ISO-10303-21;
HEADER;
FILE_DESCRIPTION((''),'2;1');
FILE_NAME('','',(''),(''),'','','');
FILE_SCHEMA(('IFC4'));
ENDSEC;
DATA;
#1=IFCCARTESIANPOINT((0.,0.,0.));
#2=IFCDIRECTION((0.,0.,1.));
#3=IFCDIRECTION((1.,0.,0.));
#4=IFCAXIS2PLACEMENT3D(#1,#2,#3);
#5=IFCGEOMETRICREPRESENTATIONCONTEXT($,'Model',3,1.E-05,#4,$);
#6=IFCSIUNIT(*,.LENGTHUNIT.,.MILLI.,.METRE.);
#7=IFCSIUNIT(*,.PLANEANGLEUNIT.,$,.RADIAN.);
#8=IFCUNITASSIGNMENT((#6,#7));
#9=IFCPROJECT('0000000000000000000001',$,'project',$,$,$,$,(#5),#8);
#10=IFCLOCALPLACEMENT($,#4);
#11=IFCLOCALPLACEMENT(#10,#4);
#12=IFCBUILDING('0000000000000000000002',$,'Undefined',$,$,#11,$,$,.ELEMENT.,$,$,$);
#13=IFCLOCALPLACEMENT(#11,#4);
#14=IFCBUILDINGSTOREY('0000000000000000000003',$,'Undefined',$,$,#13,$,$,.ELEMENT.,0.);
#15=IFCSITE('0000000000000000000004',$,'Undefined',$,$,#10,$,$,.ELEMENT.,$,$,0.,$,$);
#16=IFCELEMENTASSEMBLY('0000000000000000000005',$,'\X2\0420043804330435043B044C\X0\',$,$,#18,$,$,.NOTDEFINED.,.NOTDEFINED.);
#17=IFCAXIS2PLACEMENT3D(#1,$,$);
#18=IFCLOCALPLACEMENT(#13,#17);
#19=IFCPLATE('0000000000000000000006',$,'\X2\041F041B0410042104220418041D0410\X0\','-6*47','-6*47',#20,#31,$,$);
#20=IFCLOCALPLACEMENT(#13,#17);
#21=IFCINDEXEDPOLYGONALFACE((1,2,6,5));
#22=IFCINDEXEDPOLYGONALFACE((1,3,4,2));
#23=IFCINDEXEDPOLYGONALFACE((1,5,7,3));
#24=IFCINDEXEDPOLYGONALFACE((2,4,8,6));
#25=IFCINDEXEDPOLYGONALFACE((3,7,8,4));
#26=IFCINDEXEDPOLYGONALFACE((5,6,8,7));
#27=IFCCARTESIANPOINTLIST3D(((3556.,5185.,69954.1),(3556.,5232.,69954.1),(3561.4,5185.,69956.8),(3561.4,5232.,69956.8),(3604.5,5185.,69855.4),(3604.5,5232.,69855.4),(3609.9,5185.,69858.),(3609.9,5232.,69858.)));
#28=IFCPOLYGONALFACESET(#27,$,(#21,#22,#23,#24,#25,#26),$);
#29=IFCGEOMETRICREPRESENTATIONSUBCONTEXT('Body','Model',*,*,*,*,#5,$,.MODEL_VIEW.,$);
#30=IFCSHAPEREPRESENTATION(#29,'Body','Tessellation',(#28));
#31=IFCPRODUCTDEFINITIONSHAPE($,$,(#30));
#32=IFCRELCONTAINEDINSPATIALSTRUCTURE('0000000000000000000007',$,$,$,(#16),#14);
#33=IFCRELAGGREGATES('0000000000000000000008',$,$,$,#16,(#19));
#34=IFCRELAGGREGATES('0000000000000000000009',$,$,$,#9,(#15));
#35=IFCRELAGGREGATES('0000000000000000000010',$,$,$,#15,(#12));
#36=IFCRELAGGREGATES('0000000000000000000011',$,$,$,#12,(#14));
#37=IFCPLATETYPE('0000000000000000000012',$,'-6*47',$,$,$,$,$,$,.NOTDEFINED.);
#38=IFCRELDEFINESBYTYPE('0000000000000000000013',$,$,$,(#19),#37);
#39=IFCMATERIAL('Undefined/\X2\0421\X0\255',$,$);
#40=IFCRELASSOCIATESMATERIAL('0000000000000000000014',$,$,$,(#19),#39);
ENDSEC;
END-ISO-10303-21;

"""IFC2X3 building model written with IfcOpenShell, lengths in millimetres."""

from ifc_helpers import new_model, si_unit, frame, origin_with_axes, origin_2d_with_axis, place, context, subcontext, project, spatial, polyline, rectangle, outline, extrude, boolean, material, type_object, element, aggregate, save


model = new_model("IFC2X3")

# Units and contexts
model_context = context("Model", 3, precision=1e-05, world=origin_with_axes())
body_context = subcontext(model_context, "Body", "Model", "MODEL_VIEW")
ifc_project = project(units=[si_unit("LENGTHUNIT", "METRE", prefix="MILLI"), si_unit("PLANEANGLEUNIT", "RADIAN")], contexts=[model_context])

# Site, building, storey
site_placement = place(None, origin_with_axes())
site = spatial("IfcSite", under=ifc_project, at=site_placement, Name="Undefined", CompositionType="ELEMENT", RefElevation=0.0)
building_placement = place(site_placement, origin_with_axes())
building = spatial("IfcBuilding", under=site, at=building_placement, Name="Undefined", CompositionType="ELEMENT")
storey_placement = place(building_placement, origin_with_axes())
storey = spatial("IfcBuildingStorey", under=building, at=storey_placement, Name="Undefined", CompositionType="ELEMENT", Elevation=0.0)

# Shared definitions
ifc_material_1 = material(Name="Undefined/С255")

# Element assembly
assembly_1_placement = place(storey_placement, origin_with_axes())
assembly_1 = element("IfcElementAssembly", 1, at=assembly_1_placement, inside=storey, Name="Ригель", AssemblyPlace="NOTDEFINED", PredefinedType="NOTDEFINED")

# Shared definitions
plate_type = type_object("IfcPlateType", Name="-6*47", PredefinedType="NOTDEFINED")

# Plate
plate_1_placement = place(assembly_1_placement, frame((3607.2, 5185.0, 69856.7), z_axis=(-0.897399, 0.0, -0.441221), x_axis=(-0.441221, 0.0, 0.897399)))
plate_1 = element("IfcPlate", 2, at=plate_1_placement, type_object=plate_type, material=ifc_material_1, Name="ПЛАСТИНА", Description="-6*47", ObjectType="-6*47", context=body_context, shape_type="CSG", body=[
    boolean("DIFFERENCE", extrude(outline(polyline([(0.0, 0.0), (110.0, 0.0), (110.0, 110.0), (0.0, 110.0), (0.0, 0.0)])), frame((0.0, 0.0, -3.0), z_axis=(0.0, 0.0, 1.0), x_axis=(1.0, 0.0, 0.0)), (0.0, 0.0, 1.0), 6.0), extrude(rectangle(XDim=26.0, YDim=130.0, at=origin_2d_with_axis()), frame((55.0, 47.0, 0.0), z_axis=(0.0, 1.0, 0.0), x_axis=(0.0, 0.0, -1.0)), (0.0, 0.0, 1.0), 66.0)),
])

aggregate(assembly_1, [plate_1])

save(model, "model.ifc")
